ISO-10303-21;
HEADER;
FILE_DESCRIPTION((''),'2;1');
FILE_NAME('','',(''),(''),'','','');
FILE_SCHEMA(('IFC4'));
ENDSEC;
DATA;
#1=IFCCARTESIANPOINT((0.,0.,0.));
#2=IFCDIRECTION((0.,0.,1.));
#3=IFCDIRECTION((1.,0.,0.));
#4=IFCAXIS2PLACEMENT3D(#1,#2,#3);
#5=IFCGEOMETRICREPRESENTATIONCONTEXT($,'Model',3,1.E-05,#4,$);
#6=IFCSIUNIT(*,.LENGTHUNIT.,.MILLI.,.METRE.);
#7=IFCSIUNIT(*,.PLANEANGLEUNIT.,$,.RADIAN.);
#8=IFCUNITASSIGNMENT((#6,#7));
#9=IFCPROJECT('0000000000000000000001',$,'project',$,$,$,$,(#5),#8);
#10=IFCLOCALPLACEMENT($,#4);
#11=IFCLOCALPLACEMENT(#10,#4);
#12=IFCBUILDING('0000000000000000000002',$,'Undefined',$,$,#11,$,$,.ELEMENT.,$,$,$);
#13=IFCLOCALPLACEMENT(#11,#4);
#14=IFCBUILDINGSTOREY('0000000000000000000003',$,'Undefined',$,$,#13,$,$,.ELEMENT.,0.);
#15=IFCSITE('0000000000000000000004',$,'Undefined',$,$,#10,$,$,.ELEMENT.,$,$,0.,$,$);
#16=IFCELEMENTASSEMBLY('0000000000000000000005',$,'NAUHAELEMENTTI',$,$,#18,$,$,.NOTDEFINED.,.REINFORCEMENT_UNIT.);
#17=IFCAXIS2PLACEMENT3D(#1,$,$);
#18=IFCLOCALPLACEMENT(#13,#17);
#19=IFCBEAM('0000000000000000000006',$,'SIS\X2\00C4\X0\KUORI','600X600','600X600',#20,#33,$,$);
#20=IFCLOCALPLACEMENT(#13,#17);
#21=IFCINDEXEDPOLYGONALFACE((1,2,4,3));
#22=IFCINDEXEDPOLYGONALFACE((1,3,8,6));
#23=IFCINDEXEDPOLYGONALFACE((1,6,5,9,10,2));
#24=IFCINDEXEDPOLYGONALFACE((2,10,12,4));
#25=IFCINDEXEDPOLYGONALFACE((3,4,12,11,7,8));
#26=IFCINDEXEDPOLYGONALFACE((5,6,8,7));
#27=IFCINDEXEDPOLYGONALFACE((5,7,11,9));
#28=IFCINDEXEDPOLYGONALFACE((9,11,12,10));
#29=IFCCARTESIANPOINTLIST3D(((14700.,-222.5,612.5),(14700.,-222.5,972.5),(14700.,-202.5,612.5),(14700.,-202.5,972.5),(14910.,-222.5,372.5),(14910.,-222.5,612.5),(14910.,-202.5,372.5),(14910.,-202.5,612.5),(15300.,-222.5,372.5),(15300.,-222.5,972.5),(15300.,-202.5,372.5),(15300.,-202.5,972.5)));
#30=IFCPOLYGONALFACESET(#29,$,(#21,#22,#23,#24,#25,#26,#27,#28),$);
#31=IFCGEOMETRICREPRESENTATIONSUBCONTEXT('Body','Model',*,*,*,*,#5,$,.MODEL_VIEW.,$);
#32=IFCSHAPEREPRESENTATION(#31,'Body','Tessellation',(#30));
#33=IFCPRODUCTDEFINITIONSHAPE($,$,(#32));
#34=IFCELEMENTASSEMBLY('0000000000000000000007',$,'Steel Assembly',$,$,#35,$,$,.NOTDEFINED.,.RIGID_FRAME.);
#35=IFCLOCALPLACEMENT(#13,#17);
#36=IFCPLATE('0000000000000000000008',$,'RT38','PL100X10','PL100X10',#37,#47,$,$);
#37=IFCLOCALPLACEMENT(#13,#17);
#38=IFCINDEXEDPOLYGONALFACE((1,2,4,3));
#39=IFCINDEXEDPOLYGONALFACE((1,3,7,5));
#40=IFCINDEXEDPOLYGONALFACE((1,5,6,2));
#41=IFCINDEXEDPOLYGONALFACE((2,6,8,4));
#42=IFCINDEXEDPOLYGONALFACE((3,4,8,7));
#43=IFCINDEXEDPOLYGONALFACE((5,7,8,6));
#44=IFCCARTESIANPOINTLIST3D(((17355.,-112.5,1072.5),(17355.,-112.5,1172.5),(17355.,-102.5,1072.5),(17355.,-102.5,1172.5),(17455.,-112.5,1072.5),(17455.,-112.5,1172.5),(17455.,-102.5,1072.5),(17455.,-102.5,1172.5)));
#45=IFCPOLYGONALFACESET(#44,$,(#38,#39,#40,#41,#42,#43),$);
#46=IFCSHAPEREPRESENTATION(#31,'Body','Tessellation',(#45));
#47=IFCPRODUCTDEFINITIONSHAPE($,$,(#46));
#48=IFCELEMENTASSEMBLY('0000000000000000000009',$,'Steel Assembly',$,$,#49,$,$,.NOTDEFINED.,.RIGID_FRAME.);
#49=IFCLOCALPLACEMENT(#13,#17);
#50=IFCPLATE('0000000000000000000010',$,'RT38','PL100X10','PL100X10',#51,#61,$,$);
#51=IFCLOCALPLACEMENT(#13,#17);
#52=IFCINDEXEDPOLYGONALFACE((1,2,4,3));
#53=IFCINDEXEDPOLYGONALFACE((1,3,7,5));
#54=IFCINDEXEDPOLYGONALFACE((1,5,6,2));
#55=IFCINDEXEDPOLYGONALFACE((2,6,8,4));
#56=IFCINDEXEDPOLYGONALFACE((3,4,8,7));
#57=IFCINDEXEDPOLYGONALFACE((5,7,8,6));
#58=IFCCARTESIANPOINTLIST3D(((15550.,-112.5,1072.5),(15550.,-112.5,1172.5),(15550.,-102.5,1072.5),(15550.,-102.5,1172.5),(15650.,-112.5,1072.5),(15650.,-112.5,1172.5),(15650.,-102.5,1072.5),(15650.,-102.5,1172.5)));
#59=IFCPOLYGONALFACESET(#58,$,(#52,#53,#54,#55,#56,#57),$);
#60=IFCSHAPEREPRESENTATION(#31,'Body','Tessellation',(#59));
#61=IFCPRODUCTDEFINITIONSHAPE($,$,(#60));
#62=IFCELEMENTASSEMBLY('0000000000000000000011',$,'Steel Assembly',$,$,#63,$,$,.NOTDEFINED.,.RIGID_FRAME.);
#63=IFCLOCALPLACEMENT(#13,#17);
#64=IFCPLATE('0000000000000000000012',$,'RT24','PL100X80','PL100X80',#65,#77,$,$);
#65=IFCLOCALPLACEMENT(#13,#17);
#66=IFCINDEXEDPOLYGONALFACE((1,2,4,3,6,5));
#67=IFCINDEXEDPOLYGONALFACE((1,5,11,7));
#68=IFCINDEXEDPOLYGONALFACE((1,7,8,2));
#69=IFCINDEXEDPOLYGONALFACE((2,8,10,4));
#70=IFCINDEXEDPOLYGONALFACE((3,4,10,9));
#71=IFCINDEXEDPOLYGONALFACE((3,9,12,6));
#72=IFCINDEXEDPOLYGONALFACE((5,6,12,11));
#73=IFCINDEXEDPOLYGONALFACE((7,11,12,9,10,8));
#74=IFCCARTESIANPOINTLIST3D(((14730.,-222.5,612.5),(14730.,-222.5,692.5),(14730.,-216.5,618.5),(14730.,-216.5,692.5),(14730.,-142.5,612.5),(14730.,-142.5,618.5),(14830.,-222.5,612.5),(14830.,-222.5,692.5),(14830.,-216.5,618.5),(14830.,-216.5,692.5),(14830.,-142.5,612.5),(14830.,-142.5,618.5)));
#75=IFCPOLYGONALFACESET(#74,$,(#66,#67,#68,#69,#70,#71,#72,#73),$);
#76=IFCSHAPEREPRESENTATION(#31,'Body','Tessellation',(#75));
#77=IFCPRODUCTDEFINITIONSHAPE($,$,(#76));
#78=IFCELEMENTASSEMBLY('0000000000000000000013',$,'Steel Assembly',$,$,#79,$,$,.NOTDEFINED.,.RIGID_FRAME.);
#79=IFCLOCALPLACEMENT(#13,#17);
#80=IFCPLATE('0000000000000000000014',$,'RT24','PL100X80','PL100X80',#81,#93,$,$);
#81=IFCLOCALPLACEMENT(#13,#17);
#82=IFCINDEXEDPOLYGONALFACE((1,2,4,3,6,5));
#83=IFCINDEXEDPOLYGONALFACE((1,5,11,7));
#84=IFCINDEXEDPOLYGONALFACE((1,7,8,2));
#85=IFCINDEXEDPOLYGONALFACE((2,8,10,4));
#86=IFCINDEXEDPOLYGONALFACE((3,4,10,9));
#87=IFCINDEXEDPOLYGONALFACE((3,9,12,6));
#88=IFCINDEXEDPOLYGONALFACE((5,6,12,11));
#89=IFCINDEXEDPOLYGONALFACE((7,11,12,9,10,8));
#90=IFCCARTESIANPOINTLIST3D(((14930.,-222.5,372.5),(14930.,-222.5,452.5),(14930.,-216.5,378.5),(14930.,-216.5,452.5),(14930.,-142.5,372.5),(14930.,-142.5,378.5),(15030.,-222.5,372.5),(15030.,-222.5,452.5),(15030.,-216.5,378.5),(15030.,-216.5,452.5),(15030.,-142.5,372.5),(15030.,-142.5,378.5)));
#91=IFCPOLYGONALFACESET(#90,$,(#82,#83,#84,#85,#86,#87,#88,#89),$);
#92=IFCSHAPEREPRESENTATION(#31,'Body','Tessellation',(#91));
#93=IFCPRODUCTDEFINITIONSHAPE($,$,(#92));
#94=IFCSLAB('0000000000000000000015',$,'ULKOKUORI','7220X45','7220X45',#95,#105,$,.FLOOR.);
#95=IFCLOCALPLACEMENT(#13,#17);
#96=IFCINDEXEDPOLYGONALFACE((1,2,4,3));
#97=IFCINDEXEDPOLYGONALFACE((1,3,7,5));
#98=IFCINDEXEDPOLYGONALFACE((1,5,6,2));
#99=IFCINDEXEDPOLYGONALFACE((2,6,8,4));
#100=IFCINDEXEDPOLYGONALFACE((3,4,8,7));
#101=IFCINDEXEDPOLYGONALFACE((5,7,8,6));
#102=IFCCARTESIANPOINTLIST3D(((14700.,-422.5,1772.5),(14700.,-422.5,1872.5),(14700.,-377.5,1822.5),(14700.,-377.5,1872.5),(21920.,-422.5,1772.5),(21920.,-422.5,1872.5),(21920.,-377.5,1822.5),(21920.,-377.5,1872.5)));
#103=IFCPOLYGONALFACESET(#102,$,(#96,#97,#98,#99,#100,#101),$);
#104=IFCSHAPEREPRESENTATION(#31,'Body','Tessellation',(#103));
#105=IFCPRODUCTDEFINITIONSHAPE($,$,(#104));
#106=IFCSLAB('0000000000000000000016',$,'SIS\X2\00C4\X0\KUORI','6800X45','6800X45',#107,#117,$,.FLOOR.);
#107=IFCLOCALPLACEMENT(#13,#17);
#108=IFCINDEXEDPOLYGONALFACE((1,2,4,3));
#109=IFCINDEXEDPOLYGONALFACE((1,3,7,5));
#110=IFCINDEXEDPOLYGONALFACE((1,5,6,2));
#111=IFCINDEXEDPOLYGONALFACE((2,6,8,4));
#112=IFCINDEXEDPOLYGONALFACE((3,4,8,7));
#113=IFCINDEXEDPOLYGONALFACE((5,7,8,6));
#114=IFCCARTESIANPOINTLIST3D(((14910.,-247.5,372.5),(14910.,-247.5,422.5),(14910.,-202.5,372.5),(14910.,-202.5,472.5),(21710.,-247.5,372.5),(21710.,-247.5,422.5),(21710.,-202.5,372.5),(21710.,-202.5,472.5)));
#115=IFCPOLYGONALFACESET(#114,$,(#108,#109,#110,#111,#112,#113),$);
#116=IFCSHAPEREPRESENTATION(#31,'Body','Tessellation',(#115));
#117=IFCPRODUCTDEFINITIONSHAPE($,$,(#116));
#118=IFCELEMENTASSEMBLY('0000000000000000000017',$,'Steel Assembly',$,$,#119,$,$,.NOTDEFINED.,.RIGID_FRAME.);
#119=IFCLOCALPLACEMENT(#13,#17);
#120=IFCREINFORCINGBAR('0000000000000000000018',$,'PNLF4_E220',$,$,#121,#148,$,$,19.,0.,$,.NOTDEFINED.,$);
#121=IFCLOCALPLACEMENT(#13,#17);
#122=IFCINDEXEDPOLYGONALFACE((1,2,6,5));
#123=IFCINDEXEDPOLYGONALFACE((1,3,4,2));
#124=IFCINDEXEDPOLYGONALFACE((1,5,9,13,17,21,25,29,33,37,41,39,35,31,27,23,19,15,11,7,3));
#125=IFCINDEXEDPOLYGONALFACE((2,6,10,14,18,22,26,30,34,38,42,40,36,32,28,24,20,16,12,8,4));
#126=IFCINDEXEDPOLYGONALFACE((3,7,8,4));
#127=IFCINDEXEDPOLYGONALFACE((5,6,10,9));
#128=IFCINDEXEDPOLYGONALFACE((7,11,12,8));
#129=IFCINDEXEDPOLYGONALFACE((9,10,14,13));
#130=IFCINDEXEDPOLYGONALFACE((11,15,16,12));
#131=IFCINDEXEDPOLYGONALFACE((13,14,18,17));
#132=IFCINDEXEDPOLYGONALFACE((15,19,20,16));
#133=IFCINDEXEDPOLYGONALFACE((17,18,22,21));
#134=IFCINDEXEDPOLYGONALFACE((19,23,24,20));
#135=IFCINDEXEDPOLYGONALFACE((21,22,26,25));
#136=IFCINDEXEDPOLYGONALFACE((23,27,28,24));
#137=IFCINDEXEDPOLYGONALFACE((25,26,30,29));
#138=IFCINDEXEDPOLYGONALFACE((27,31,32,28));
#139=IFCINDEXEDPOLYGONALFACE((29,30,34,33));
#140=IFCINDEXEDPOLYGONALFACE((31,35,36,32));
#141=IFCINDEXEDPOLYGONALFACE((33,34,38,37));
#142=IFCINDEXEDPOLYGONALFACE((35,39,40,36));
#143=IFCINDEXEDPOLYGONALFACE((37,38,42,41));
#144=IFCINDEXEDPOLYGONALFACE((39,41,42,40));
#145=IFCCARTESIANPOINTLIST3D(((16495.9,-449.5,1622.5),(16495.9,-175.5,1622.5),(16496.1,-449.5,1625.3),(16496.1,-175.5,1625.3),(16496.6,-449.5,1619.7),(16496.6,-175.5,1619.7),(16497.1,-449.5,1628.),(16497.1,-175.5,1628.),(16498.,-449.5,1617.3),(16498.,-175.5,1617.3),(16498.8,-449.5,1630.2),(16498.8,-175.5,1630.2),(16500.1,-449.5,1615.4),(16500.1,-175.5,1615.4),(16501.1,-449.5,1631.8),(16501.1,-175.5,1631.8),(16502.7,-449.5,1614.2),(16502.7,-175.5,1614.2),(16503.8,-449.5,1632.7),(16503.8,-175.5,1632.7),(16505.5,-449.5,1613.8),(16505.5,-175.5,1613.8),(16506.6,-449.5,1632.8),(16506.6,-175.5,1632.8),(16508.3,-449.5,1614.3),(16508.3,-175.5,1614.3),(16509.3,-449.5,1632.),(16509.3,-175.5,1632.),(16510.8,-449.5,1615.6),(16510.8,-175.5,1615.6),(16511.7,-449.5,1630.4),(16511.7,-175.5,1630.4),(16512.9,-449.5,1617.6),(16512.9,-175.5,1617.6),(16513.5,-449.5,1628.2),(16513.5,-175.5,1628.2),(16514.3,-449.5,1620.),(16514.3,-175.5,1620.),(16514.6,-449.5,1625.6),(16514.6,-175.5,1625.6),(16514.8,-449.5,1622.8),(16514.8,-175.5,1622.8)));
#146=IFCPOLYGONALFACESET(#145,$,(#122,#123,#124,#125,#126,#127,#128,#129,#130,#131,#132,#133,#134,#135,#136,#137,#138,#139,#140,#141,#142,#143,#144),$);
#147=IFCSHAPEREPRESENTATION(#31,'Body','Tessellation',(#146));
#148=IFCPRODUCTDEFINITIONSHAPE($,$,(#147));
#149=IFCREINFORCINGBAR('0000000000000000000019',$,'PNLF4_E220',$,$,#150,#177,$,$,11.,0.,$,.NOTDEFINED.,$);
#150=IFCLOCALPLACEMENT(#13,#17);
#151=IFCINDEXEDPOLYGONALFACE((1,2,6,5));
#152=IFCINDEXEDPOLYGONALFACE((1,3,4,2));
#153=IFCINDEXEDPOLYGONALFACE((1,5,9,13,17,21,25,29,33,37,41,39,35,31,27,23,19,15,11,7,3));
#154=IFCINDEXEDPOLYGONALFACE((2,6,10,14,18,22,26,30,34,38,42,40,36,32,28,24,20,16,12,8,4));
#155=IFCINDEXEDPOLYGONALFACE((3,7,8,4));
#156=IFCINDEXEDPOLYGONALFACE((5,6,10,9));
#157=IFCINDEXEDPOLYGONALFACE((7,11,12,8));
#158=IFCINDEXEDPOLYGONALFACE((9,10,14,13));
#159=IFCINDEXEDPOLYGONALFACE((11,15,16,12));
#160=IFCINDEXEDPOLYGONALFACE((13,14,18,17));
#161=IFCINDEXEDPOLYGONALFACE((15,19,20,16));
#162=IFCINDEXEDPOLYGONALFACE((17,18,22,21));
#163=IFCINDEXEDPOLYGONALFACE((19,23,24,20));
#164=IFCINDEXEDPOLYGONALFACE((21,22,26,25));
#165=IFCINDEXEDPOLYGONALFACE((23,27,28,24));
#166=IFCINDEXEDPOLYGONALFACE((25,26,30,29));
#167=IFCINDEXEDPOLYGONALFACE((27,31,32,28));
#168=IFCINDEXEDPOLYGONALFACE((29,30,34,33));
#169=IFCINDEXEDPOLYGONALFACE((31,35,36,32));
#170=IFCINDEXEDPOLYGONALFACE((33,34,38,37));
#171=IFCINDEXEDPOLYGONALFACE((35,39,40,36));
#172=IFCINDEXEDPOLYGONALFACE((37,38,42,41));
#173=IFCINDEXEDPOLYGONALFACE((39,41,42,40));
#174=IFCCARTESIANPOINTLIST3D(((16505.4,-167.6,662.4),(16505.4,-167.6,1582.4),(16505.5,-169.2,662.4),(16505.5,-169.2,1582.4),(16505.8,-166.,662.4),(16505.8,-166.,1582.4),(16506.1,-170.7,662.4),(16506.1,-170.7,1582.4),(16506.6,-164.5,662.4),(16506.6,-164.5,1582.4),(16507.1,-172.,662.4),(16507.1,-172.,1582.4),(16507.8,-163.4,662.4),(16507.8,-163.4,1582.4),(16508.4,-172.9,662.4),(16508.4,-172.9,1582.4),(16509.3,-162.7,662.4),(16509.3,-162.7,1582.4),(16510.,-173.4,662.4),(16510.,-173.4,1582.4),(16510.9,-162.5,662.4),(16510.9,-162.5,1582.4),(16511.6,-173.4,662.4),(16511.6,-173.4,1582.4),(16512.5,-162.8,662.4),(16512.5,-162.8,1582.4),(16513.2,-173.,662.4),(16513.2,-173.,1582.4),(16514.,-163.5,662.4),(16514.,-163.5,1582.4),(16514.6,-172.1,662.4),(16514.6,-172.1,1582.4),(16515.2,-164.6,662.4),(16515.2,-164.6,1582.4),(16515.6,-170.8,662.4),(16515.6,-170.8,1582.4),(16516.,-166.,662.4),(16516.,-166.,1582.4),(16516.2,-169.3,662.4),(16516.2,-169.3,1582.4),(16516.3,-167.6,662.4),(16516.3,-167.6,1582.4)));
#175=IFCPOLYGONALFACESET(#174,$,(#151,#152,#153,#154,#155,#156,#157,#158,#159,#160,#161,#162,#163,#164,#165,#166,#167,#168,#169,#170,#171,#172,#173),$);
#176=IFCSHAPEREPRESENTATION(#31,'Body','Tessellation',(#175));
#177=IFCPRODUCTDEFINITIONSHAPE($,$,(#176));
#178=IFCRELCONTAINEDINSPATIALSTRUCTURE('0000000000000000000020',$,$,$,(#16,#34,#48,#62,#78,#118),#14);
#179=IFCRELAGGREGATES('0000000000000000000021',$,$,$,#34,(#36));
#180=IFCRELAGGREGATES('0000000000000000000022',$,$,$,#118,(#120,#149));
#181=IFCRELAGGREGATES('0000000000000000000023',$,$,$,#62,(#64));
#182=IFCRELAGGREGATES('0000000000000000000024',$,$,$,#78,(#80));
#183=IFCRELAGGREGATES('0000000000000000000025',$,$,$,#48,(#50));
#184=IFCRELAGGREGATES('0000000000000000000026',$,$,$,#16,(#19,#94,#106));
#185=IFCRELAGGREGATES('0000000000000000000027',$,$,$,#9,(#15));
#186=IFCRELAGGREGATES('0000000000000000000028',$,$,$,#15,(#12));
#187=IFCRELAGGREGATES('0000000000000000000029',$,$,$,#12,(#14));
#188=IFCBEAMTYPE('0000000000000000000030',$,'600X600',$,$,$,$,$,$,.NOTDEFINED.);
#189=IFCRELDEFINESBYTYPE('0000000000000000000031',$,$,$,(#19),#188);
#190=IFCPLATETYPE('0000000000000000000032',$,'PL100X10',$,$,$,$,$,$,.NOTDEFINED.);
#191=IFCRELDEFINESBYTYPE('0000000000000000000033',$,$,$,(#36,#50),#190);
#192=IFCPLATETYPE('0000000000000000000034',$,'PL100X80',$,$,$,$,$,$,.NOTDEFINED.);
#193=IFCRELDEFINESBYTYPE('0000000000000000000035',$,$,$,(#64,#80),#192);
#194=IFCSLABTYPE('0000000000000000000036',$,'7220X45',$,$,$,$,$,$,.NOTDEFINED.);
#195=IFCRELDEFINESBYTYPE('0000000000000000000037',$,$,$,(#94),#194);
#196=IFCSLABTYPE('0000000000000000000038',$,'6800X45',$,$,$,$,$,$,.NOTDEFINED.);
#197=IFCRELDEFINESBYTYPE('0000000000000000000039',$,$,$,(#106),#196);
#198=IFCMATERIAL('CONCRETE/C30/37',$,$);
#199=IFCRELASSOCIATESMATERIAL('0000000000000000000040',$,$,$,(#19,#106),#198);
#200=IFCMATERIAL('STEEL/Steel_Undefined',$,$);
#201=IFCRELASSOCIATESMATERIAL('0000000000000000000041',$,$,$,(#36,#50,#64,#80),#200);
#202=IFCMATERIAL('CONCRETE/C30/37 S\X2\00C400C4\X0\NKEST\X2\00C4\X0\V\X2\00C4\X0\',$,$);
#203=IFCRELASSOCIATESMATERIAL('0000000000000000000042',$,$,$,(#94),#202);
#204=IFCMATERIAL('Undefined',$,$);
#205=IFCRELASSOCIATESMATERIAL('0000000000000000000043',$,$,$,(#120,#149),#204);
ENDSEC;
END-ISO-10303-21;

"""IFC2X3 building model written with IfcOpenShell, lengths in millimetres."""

from ifc_helpers import new_model, entity, si_unit, frame, origin_with_axes, origin_2d_with_axis, place, context, subcontext, project, spatial, polyline, rectangle, outline, extrude, boolean, source, transform, mapped, material, type_object, element, aggregate, save


model = new_model("IFC2X3")

# Units and contexts
model_context = context("Model", 3, precision=1e-05, world=origin_with_axes())
body_context = subcontext(model_context, "Body", "Model", "MODEL_VIEW")
ifc_project = project(units=[si_unit("LENGTHUNIT", "METRE", prefix="MILLI"), si_unit("PLANEANGLEUNIT", "RADIAN")], contexts=[model_context])

# Site, building, storey
site_placement = place(None, origin_with_axes())
site = spatial("IfcSite", under=ifc_project, at=site_placement, Name="Undefined", CompositionType="ELEMENT", RefElevation=0.0)
building_placement = place(site_placement, origin_with_axes())
building = spatial("IfcBuilding", under=site, at=building_placement, Name="Undefined", CompositionType="ELEMENT")
storey_placement = place(building_placement, origin_with_axes())
storey = spatial("IfcBuildingStorey", under=building, at=storey_placement, Name="Undefined", CompositionType="ELEMENT", Elevation=0.0)

# Element assembly, beam
assembly_1_placement = place(storey_placement, origin_with_axes())
assembly_1 = element("IfcElementAssembly", 1, at=assembly_1_placement, inside=storey, Name="NAUHAELEMENTTI", AssemblyPlace="NOTDEFINED", PredefinedType="REINFORCEMENT_UNIT")
ifc_material_1 = material(Name="CONCRETE/C30/37")
beam_type = type_object("IfcBeamType", Name="600X600", PredefinedType="NOTDEFINED")
beam_placement = place(assembly_1_placement, frame((15000.0, -202.5, 672.5), z_axis=(0.0, 0.0, 1.0), x_axis=(0.0, -1.0, 0.0)))
beam = element("IfcBeam", 2, at=beam_placement, type_object=beam_type, material=ifc_material_1, Name="SISÄKUORI", Description="600X600", ObjectType="600X600", context=body_context, shape_type="CSG", body=[
    boolean("DIFFERENCE", extrude(rectangle(XDim=600.0, YDim=600.0, at=origin_2d_with_axis()), frame((20.0, 0.0, 0.0), z_axis=(-1.0, 0.0, 0.0), x_axis=(0.0, -1.0, 0.0)), (0.0, 0.0, 1.0), 20.0), extrude(rectangle(XDim=210.0, YDim=240.0, at=origin_2d_with_axis()), frame((300.0, -195.0, -180.0), z_axis=(-1.0, 0.0, 0.0), x_axis=(0.0, -1.0, 0.0)), (0.0, 0.0, 1.0), 500.0)),
])

# Element assemblies, plates
assembly_2_placement = place(storey_placement, origin_with_axes())
assembly_2 = element("IfcElementAssembly", 3, at=assembly_2_placement, inside=storey, Name="Steel Assembly", AssemblyPlace="NOTDEFINED", PredefinedType="RIGID_FRAME")
ifc_material_2 = material(Name="STEEL/Steel_Undefined")
plate_type_1 = type_object("IfcPlateType", Name="PL100X10", PredefinedType="NOTDEFINED")
plate_1_placement = place(assembly_2_placement, frame((17405.0, -112.5, 1072.5), z_axis=(-1.0, 0.0, 0.0), x_axis=(0.0, 0.0, 1.0)))
plate_1 = element("IfcPlate", 4, at=plate_1_placement, type_object=plate_type_1, material=ifc_material_2, Name="RT38", Description="PL100X10", ObjectType="PL100X10", context=body_context, shape_type="SweptSolid", body=[
    extrude(outline(polyline([(0.0, 0.0), (100.0, 0.0), (100.0, 10.0), (0.0, 10.0), (0.0, 0.0)])), frame((0.0, 0.0, -50.0), z_axis=(0.0, 0.0, 1.0), x_axis=(1.0, 0.0, 0.0)), (0.0, 0.0, 1.0), 100.0),
])
assembly_3_placement = place(storey_placement, origin_with_axes())
assembly_3 = element("IfcElementAssembly", 5, at=assembly_3_placement, inside=storey, Name="Steel Assembly", AssemblyPlace="NOTDEFINED", PredefinedType="RIGID_FRAME")
plate_2_placement = place(assembly_3_placement, frame((15600.0, -112.5, 1072.5), z_axis=(-1.0, 0.0, 0.0), x_axis=(0.0, 0.0, 1.0)))
plate_2 = element("IfcPlate", 6, at=plate_2_placement, type_object=plate_type_1, material=ifc_material_2, Name="RT38", Description="PL100X10", ObjectType="PL100X10", context=body_context, shape_type="SweptSolid", body=[
    extrude(outline(polyline([(0.0, 0.0), (100.0, 0.0), (100.0, 10.0), (0.0, 10.0), (0.0, 0.0)])), frame((0.0, 0.0, -50.0), z_axis=(0.0, 0.0, 1.0), x_axis=(1.0, 0.0, 0.0)), (0.0, 0.0, 1.0), 100.0),
])
assembly_4_placement = place(storey_placement, origin_with_axes())
assembly_4 = element("IfcElementAssembly", 7, at=assembly_4_placement, inside=storey, Name="Steel Assembly", AssemblyPlace="NOTDEFINED", PredefinedType="RIGID_FRAME")
plate_type_2 = type_object("IfcPlateType", Name="PL100X80", PredefinedType="NOTDEFINED")
plate_3_placement = place(assembly_4_placement, frame((14780.0, -222.5, 612.5), z_axis=(1.0, 0.0, 0.0), x_axis=(0.0, 1.0, 0.0)))
plate_3 = element("IfcPlate", 8, at=plate_3_placement, type_object=plate_type_2, material=ifc_material_2, Name="RT24", Description="PL100X80", ObjectType="PL100X80", context=body_context, shape_type="SweptSolid", body=[
    extrude(outline(polyline([(0.0, 0.0), (80.0, 0.0), (80.0, 6.0), (6.0, 6.0), (6.0, 80.0), (0.0, 80.0), (0.0, 0.0)])), frame((0.0, 0.0, -50.0), z_axis=(0.0, 0.0, 1.0), x_axis=(1.0, 0.0, 0.0)), (0.0, 0.0, 1.0), 100.0),
])
assembly_5_placement = place(storey_placement, origin_with_axes())
assembly_5 = element("IfcElementAssembly", 9, at=assembly_5_placement, inside=storey, Name="Steel Assembly", AssemblyPlace="NOTDEFINED", PredefinedType="RIGID_FRAME")
plate_4_placement = place(assembly_5_placement, frame((14980.0, -222.5, 372.5), z_axis=(1.0, 0.0, 0.0), x_axis=(0.0, 1.0, 0.0)))
plate_4 = element("IfcPlate", 10, at=plate_4_placement, type_object=plate_type_2, material=ifc_material_2, Name="RT24", Description="PL100X80", ObjectType="PL100X80", context=body_context, shape_type="SweptSolid", body=[
    extrude(outline(polyline([(0.0, 0.0), (80.0, 0.0), (80.0, 6.0), (6.0, 6.0), (6.0, 80.0), (0.0, 80.0), (0.0, 0.0)])), frame((0.0, 0.0, -50.0), z_axis=(0.0, 0.0, 1.0), x_axis=(1.0, 0.0, 0.0)), (0.0, 0.0, 1.0), 100.0),
])

# Slabs
ifc_material_3 = material(Name="CONCRETE/C30/37 SÄÄNKESTÄVÄ")
slab_type_1 = type_object("IfcSlabType", Name="7220X45", PredefinedType="NOTDEFINED")
slab_1_placement = place(assembly_1_placement, frame((18310.0, -377.5, 1872.5), z_axis=(1.0, 0.0, 0.0), x_axis=(0.0, -1.0, 0.0)))
slab_1 = element("IfcSlab", 11, at=slab_1_placement, type_object=slab_type_1, material=ifc_material_3, Name="ULKOKUORI", Description="7220X45", ObjectType="7220X45", PredefinedType="FLOOR", context=body_context, shape_type="SweptSolid", body=[
    extrude(outline(polyline([(0.0, 0.0), (45.0, 0.0), (45.0, 100.0), (0.0, 50.0), (0.0, 0.0)])), frame((0.0, 0.0, -3610.0), z_axis=(0.0, 0.0, 1.0), x_axis=(1.0, 0.0, 0.0)), (0.0, 0.0, 1.0), 7220.0),
])
slab_type_2 = type_object("IfcSlabType", Name="6800X45", PredefinedType="NOTDEFINED")
slab_2_placement = place(assembly_1_placement, frame((18310.0, -247.5, 372.5), z_axis=(1.0, 0.0, 0.0), x_axis=(0.0, 1.0, 0.0)))
slab_2 = element("IfcSlab", 12, at=slab_2_placement, type_object=slab_type_2, material=ifc_material_1, Name="SISÄKUORI", Description="6800X45", ObjectType="6800X45", PredefinedType="FLOOR", context=body_context, shape_type="SweptSolid", body=[
    extrude(outline(polyline([(0.0, 0.0), (45.0, 0.0), (45.0, 100.0), (0.0, 50.0), (0.0, 0.0)])), frame((0.0, 0.0, -3400.0), z_axis=(0.0, 0.0, 1.0), x_axis=(1.0, 0.0, 0.0)), (0.0, 0.0, 1.0), 6800.0),
])

# Shared definitions
ifc_material_4 = material(Name="Undefined")
aggregate(assembly_2, [plate_1])

# Element assembly, reinforcing bars
assembly_6_placement = place(storey_placement, origin_with_axes())
assembly_6 = element("IfcElementAssembly", 13, at=assembly_6_placement, inside=storey, Name="Steel Assembly", AssemblyPlace="NOTDEFINED", PredefinedType="RIGID_FRAME")
shared_shape_1 = source(origin_with_axes(), body_context, "Body", "AdvancedSweptSolid", [
    entity("IfcSweptDiskSolid", entity("IfcTrimmedCurve", entity("IfcLine", entity("IfcCartesianPoint", [0.0, 0.0, 0.0]), entity("IfcVector", entity("IfcDirection", [1.0, 0.0, 0.0]), 1.0)), [entity("IfcParameterValue", 0.0)], [entity("IfcParameterValue", 274.0)], True, "PARAMETER"), 9.5, None, 0.0, 274.0),
])
reinforcing_bar_1_placement = place(assembly_6_placement, frame((16505.4, -175.5, 1623.3), z_axis=(0.016991, 0.0, -0.999856), x_axis=(0.0, -1.0, 0.0)))
reinforcing_bar_1 = element("IfcReinforcingBar", 14, at=reinforcing_bar_1_placement, material=ifc_material_4, Name="PNLF4_E220", BarRole="NOTDEFINED", CrossSectionArea=0.0, NominalDiameter=19.0, context=body_context, shape_type="MappedRepresentation", body=[
    mapped(shared_shape_1, transform((0.0, 0.0, 0.0))),
])
shared_shape_2 = source(origin_with_axes(), body_context, "Body", "AdvancedSweptSolid", [
    entity("IfcSweptDiskSolid", entity("IfcTrimmedCurve", entity("IfcLine", entity("IfcCartesianPoint", [0.0, 0.0, 0.0]), entity("IfcVector", entity("IfcDirection", [1.0, 0.0, 0.0]), 1.0)), [entity("IfcParameterValue", 0.0)], [entity("IfcParameterValue", 920.0)], True, "PARAMETER"), 5.5, None, 0.0, 920.0),
])
reinforcing_bar_2_placement = place(assembly_6_placement, frame((16510.9, -168.0, 1582.4), z_axis=(0.006957, 0.999976, 0.0), x_axis=(0.0, 0.0, -1.0)))
reinforcing_bar_2 = element("IfcReinforcingBar", 15, at=reinforcing_bar_2_placement, material=ifc_material_4, Name="PNLF4_E220", BarRole="NOTDEFINED", CrossSectionArea=0.0, NominalDiameter=11.0, context=body_context, shape_type="MappedRepresentation", body=[
    mapped(shared_shape_2, transform((0.0, 0.0, 0.0))),
])
aggregate(assembly_6, [reinforcing_bar_1, reinforcing_bar_2])

aggregate(assembly_4, [plate_3])
aggregate(assembly_5, [plate_4])
aggregate(assembly_3, [plate_2])
aggregate(assembly_1, [beam, slab_1, slab_2])

save(model, "model.ifc")
